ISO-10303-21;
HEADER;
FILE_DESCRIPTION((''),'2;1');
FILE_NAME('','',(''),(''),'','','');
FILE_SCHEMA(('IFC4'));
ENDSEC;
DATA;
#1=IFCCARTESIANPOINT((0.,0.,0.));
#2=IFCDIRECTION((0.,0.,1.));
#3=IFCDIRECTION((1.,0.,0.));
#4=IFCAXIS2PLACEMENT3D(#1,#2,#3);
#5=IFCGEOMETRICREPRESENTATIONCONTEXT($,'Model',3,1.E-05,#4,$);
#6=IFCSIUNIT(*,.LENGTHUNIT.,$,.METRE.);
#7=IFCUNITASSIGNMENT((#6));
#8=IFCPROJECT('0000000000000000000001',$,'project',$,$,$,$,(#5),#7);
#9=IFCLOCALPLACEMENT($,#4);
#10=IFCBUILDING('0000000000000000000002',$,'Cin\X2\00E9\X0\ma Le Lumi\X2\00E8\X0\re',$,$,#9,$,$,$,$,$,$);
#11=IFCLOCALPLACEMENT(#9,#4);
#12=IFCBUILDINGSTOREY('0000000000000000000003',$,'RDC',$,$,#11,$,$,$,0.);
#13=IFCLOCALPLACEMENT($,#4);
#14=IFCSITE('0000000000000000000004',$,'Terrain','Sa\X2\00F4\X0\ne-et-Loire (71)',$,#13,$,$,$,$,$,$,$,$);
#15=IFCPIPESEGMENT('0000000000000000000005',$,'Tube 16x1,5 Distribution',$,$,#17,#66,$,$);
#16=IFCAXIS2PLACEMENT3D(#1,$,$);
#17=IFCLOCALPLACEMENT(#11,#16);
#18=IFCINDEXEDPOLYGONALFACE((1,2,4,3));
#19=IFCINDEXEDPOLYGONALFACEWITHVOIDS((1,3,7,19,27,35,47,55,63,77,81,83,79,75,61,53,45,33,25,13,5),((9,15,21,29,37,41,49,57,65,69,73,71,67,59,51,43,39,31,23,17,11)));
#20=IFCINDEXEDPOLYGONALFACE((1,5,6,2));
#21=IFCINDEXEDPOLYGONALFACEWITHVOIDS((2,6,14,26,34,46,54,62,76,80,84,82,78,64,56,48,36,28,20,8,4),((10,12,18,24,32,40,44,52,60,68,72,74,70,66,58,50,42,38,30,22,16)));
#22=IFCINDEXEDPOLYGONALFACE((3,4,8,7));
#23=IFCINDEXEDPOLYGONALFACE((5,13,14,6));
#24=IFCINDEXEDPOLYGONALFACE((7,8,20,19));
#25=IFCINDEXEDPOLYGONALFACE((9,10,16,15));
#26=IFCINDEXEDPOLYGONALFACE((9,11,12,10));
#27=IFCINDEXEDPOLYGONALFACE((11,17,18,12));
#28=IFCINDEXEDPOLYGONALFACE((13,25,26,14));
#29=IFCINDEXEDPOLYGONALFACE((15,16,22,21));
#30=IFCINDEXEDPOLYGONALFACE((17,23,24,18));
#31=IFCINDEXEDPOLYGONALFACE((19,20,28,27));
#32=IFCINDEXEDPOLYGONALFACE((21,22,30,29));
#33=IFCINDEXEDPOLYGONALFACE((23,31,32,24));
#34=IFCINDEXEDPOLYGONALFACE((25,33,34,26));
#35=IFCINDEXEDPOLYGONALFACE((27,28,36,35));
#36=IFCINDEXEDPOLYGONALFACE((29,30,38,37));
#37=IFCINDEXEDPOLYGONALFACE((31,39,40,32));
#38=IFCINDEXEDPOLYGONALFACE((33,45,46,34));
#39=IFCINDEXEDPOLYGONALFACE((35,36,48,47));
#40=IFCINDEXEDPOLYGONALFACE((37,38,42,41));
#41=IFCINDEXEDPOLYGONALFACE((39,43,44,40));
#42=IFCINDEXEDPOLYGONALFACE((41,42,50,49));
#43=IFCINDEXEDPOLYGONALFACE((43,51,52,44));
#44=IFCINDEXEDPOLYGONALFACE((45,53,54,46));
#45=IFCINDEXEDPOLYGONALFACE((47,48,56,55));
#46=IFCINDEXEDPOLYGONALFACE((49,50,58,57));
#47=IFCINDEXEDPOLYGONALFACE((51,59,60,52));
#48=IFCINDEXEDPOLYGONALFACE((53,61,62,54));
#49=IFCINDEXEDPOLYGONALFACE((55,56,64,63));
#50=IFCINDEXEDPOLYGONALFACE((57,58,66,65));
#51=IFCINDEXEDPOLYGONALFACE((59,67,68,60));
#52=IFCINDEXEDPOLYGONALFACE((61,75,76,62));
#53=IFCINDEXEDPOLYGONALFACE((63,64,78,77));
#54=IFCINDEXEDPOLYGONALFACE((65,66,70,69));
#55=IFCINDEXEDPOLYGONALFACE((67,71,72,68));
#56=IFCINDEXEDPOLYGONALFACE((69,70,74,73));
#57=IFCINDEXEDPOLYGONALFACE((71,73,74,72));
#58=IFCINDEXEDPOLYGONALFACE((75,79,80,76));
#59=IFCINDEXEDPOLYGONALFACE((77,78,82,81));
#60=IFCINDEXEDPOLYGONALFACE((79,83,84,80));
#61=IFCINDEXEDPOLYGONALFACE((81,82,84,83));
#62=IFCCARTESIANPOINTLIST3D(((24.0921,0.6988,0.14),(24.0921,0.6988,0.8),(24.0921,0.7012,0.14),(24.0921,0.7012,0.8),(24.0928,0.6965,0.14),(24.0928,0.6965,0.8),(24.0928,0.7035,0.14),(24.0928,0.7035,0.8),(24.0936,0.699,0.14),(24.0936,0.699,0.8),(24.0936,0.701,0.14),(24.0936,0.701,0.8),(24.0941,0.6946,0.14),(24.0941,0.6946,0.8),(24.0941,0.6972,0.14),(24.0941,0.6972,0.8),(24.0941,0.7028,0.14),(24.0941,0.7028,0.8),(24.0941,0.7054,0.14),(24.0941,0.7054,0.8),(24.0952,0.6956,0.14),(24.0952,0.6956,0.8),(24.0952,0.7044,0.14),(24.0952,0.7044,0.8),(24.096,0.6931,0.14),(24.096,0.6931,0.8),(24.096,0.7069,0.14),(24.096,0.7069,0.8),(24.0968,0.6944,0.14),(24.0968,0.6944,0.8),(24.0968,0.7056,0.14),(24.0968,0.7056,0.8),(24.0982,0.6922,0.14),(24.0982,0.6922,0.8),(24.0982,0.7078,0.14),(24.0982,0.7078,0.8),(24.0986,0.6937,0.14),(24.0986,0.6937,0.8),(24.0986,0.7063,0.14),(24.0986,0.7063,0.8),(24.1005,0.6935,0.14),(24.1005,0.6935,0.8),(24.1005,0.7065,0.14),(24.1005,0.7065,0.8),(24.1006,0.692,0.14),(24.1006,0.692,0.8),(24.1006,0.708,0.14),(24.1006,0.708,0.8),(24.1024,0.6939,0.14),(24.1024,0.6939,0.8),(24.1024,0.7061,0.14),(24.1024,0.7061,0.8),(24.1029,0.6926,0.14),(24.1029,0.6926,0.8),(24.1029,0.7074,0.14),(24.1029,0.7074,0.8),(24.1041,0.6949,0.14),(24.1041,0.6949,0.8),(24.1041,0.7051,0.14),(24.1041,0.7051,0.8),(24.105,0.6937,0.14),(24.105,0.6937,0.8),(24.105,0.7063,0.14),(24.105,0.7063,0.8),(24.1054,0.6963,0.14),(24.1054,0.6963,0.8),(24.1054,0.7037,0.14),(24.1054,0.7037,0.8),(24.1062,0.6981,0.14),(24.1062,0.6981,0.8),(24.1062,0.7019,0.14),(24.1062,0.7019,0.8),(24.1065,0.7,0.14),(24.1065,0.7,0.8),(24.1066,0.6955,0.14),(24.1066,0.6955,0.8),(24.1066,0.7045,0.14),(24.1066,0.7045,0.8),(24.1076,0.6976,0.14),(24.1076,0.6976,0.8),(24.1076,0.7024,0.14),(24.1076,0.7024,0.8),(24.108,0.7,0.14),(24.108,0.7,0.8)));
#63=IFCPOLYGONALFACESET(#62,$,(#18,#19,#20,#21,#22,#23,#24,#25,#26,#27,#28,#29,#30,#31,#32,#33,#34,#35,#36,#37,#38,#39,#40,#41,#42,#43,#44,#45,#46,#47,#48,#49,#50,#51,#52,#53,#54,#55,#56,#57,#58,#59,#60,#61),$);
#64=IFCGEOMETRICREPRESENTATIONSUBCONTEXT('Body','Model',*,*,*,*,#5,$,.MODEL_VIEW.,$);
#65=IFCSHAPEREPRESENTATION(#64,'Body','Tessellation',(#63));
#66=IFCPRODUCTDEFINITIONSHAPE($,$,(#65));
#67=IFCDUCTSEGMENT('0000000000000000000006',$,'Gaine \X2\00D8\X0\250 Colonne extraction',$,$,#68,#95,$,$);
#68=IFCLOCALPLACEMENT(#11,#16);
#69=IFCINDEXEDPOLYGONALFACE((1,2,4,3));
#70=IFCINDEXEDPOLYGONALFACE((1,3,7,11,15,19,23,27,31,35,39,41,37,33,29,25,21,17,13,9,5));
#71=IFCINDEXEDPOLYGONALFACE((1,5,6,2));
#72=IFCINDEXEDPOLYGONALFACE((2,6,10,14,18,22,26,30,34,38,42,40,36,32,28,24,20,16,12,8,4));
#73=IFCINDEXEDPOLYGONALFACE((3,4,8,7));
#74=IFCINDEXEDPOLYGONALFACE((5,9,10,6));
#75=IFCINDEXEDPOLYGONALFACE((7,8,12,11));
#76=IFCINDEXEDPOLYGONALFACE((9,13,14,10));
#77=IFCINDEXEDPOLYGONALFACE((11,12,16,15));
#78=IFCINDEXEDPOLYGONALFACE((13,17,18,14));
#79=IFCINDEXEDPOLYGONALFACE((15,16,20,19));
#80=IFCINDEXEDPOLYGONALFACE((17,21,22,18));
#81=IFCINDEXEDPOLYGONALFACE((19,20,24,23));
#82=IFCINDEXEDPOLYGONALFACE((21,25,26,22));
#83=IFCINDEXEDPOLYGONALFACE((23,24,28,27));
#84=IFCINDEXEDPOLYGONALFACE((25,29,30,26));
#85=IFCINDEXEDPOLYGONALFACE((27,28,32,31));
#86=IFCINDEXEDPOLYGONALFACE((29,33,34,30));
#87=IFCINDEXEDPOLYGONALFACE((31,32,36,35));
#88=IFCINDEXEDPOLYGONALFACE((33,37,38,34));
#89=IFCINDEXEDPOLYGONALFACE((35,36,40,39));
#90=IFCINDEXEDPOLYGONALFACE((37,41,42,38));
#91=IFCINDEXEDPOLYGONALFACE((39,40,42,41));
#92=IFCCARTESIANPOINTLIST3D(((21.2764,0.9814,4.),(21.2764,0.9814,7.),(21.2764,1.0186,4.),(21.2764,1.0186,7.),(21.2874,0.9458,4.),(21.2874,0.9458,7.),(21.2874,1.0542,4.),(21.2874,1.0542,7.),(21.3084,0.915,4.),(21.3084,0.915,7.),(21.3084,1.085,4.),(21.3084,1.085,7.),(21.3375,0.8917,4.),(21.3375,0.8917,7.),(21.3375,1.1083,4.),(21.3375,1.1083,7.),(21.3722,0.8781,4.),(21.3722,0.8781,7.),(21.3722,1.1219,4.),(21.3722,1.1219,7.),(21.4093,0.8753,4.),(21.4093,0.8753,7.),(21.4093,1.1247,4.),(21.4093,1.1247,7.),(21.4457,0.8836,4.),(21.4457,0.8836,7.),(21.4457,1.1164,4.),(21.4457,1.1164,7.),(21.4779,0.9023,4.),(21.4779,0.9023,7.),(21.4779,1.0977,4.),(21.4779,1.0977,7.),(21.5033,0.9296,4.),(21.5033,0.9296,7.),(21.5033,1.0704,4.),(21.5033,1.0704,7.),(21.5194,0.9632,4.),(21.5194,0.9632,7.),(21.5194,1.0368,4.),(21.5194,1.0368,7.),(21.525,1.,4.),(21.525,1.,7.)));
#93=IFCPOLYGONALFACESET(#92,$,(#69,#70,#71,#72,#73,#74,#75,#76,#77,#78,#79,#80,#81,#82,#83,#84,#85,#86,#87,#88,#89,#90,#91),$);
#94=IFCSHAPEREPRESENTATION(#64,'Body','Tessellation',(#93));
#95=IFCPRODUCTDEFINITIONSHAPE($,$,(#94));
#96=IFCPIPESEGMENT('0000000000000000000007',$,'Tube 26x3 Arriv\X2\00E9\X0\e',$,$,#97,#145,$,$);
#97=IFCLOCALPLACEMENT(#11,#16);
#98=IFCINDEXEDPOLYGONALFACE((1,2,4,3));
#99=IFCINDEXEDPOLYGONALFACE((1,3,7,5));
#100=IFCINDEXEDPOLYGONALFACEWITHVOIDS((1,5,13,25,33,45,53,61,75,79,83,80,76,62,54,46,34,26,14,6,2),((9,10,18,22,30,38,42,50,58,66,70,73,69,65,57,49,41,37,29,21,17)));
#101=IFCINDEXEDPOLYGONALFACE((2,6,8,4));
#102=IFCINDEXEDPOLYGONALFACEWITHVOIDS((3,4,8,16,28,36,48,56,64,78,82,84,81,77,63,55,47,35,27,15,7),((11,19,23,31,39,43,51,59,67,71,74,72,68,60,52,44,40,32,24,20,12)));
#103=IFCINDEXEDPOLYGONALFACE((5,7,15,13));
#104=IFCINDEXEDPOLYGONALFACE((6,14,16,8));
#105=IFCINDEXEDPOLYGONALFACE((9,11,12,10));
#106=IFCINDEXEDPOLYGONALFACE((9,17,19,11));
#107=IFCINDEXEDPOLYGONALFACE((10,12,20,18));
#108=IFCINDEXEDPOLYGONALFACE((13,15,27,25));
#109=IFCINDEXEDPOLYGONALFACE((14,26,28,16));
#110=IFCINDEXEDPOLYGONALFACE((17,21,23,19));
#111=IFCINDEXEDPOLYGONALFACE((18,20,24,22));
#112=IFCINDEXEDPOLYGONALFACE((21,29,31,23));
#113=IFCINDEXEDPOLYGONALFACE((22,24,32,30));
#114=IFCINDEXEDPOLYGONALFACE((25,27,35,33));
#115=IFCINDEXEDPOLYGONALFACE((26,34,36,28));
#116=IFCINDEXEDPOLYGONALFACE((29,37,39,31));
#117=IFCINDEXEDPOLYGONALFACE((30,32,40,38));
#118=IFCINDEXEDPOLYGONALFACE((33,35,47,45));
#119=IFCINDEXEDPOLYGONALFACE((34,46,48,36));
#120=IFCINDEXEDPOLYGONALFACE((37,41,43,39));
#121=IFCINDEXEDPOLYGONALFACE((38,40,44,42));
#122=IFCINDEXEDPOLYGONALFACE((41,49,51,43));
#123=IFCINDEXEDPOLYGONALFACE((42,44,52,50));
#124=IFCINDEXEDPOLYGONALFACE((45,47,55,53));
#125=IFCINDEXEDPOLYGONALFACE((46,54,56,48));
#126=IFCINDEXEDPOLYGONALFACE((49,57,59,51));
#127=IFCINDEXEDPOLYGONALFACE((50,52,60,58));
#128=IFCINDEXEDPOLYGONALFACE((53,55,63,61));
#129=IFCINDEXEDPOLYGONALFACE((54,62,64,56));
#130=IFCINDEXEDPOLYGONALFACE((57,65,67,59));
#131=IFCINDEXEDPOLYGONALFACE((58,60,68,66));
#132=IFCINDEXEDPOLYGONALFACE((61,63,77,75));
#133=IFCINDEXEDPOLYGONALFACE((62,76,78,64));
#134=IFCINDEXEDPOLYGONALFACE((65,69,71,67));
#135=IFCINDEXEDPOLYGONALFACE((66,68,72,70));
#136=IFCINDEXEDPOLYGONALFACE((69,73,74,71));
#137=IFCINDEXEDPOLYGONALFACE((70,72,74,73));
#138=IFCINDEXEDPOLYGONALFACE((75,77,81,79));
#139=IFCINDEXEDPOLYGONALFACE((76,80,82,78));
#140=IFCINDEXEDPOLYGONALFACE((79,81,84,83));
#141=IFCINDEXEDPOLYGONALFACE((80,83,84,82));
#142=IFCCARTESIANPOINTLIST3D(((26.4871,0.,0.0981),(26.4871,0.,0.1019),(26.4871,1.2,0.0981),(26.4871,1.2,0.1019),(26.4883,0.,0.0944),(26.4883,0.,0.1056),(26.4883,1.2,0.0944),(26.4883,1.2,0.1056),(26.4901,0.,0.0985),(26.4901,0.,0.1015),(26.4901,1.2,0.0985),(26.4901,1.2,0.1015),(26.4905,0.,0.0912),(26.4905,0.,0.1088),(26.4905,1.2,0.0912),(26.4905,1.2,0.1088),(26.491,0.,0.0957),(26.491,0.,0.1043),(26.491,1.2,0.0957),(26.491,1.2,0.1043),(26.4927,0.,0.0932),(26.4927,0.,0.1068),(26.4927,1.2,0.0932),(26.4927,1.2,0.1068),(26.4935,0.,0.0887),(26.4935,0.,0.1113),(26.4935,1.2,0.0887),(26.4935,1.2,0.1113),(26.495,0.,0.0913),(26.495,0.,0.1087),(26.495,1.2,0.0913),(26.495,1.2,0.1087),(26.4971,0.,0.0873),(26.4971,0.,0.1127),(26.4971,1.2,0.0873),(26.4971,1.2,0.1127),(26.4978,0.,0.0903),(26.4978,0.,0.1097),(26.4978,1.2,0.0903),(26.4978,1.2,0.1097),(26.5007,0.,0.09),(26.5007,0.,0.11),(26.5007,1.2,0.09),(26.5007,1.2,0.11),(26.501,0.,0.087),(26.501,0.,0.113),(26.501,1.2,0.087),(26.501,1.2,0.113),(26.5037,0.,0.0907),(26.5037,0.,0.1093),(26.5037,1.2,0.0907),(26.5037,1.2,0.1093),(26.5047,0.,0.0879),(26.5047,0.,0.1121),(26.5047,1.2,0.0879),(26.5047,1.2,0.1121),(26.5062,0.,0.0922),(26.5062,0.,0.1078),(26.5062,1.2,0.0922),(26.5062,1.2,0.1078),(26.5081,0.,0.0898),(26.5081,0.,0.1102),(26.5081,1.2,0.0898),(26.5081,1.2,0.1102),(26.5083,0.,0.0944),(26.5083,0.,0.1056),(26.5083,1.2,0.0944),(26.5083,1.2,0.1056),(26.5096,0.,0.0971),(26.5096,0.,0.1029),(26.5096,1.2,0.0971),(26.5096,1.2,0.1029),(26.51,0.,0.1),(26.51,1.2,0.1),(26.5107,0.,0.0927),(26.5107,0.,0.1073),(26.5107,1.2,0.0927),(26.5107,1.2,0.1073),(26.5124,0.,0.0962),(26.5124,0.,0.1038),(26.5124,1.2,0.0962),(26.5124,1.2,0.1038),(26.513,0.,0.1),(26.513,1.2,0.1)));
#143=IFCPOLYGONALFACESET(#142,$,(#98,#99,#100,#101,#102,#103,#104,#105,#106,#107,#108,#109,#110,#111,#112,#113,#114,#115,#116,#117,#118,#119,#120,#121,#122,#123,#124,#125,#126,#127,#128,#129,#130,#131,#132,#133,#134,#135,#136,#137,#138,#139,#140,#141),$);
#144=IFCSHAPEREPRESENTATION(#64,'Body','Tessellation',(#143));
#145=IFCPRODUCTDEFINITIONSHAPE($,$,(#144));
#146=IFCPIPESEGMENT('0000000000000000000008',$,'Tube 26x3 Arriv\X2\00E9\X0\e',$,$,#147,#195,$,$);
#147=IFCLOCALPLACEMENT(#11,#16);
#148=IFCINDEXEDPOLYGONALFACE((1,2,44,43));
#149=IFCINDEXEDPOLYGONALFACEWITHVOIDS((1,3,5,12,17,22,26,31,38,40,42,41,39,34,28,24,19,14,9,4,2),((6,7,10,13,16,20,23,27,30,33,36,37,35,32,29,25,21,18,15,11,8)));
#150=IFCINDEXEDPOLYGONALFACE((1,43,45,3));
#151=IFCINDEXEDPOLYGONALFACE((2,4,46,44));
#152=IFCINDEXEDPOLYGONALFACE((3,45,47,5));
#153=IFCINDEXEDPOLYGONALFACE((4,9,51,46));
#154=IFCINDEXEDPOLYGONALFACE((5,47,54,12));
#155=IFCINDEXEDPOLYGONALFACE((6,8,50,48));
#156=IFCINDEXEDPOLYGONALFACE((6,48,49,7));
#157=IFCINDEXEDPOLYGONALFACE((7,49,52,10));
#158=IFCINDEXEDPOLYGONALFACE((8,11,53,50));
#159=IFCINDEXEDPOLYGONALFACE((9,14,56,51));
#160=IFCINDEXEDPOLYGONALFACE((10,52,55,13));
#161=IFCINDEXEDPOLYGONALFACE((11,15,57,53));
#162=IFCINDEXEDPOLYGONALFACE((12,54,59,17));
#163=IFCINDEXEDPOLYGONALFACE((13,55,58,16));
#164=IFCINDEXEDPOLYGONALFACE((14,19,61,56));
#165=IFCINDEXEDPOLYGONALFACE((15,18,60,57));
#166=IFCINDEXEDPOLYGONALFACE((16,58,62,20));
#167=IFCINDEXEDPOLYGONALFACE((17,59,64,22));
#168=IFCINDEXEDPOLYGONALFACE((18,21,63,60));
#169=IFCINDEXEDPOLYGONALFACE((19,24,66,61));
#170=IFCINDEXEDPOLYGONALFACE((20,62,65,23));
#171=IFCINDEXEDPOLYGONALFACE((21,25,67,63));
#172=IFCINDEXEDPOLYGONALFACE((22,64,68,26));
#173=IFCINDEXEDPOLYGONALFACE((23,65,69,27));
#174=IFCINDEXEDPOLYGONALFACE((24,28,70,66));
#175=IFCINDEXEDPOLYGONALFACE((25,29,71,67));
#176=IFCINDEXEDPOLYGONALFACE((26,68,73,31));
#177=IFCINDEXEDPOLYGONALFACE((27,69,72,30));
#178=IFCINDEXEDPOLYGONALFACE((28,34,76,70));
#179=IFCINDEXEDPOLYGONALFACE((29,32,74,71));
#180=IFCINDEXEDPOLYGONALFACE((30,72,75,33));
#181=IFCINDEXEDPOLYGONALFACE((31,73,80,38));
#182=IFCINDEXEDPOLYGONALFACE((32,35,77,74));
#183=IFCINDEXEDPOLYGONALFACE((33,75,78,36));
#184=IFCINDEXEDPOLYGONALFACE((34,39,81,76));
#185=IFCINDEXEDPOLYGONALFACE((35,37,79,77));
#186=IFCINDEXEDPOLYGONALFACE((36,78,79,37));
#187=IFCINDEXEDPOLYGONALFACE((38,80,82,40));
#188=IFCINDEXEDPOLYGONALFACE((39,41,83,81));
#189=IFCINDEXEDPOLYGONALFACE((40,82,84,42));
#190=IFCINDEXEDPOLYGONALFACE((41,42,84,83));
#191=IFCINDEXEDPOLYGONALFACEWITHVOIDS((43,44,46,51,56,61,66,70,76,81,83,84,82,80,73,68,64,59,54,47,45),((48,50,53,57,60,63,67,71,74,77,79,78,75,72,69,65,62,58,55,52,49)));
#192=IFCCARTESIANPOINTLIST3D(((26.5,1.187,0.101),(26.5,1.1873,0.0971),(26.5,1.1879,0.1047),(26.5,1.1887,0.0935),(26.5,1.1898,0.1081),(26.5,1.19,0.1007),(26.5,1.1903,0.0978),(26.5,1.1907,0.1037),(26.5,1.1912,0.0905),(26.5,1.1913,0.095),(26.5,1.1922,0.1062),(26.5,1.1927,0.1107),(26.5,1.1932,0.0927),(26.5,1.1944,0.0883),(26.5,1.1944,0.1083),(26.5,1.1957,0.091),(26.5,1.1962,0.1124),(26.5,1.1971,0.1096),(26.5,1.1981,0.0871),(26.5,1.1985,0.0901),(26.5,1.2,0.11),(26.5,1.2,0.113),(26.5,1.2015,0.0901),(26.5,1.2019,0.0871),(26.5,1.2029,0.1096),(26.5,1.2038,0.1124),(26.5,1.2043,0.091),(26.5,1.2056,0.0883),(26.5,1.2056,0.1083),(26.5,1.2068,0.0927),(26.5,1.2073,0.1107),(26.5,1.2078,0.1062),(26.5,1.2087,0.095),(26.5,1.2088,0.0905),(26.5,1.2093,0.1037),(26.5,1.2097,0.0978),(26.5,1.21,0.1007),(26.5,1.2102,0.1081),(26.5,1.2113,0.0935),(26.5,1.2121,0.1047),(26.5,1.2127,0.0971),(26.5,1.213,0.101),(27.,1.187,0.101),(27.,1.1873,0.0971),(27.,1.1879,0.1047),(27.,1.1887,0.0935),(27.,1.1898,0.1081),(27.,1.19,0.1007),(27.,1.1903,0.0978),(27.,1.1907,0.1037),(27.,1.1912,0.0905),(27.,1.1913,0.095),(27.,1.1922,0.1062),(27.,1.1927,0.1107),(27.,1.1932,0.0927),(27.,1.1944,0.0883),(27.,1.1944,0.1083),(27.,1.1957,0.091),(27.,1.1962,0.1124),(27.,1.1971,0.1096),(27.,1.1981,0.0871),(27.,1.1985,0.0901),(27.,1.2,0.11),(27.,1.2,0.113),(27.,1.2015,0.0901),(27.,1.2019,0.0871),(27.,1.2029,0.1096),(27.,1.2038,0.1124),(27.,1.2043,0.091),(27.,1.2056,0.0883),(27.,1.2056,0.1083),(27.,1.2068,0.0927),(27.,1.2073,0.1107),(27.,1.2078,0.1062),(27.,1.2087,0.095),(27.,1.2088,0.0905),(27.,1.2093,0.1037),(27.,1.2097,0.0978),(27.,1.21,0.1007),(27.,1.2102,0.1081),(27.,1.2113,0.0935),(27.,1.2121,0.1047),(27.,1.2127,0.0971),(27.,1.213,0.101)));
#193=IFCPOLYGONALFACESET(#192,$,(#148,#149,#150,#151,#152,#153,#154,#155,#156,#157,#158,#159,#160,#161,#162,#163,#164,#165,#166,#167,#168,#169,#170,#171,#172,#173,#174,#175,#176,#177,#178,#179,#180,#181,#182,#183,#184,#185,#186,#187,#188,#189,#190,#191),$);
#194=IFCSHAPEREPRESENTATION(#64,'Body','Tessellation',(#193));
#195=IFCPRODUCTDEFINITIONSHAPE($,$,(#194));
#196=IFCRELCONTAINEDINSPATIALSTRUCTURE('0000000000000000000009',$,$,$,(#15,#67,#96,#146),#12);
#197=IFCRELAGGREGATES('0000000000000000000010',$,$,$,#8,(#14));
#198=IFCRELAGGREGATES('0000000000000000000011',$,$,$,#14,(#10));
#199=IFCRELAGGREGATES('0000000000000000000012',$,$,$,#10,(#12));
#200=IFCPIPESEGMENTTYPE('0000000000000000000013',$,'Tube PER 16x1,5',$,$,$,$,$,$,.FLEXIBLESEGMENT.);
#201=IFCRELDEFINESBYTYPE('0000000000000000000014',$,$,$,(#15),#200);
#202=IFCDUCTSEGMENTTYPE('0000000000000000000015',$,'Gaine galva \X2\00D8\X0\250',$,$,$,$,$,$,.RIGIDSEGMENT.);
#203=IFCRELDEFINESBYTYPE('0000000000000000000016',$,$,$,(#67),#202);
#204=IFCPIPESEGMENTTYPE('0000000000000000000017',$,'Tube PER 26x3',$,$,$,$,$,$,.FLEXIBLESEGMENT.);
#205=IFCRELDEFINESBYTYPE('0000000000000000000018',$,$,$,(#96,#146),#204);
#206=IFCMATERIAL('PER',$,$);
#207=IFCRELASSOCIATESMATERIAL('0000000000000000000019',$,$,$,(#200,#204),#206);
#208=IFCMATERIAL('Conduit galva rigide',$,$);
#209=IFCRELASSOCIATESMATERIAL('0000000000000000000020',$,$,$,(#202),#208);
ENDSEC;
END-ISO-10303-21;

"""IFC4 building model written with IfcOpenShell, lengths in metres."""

from ifc_helpers import new_model, si_unit, frame, origin_with_axes, place, context, subcontext, project, spatial, circle, hollow_circle, extrude, material, type_object, element, save


model = new_model("IFC4")

# Units and contexts
model_context = context("Model", 3, precision=1e-05, world=origin_with_axes())
body_context = subcontext(model_context, "Body", "Model", "MODEL_VIEW")
ifc_project = project(units=[si_unit("LENGTHUNIT", "METRE")], contexts=[model_context])

# Site, building, storey
site_placement = place(None, origin_with_axes())
site = spatial("IfcSite", under=ifc_project, at=site_placement, Name="Terrain", Description="Saône-et-Loire (71)")
building_placement = place(None, origin_with_axes())
building = spatial("IfcBuilding", under=site, at=building_placement, Name="Cinéma Le Lumière")
storey_placement = place(building_placement, origin_with_axes())
storey = spatial("IfcBuildingStorey", under=building, at=storey_placement, Name="RDC", Elevation=0.0)

# Shared definitions
ifc_material_1 = material(Name="Conduit galva rigide")

# Pipe segment
ifc_material_2 = material(Name="PER")
pipe_segment_type_1 = type_object("IfcPipeSegmentType", Name="Tube PER 16x1,5", PredefinedType="FLEXIBLESEGMENT", material=ifc_material_2)
pipe_segment_1_placement = place(storey_placement, frame((24.1, 0.7, 0.14), z_axis=(0.0, 0.0, 1.0), x_axis=(1.0, 0.0, 0.0)))
element("IfcPipeSegment", 1, at=pipe_segment_1_placement, inside=storey, type_object=pipe_segment_type_1, Name="Tube 16x1,5 Distribution", context=body_context, shape_type="SweptSolid", body=[
    extrude(hollow_circle(Radius=0.008, WallThickness=0.0015), origin_with_axes(), (0.0, 0.0, 1.0), 0.66),
])

# Duct segment
duct_segment_type_1 = type_object("IfcDuctSegmentType", Name="Gaine galva Ø250", PredefinedType="RIGIDSEGMENT", material=ifc_material_1)
duct_segment_1_placement = place(storey_placement, frame((21.4, 1.0, 4.0), z_axis=(0.0, 0.0, 1.0), x_axis=(1.0, 0.0, 0.0)))
element("IfcDuctSegment", 2, at=duct_segment_1_placement, inside=storey, type_object=duct_segment_type_1, Name="Gaine Ø250 Colonne extraction", context=body_context, shape_type="SweptSolid", body=[
    extrude(circle(Radius=0.125), origin_with_axes(), (0.0, 0.0, 1.0), 3.0),
])

# Pipe segments
pipe_segment_type_2 = type_object("IfcPipeSegmentType", Name="Tube PER 26x3", PredefinedType="FLEXIBLESEGMENT", material=ifc_material_2)
pipe_segment_2_placement = place(storey_placement, frame((26.5, 0.0, 0.1), z_axis=(0.0, 1.0, 0.0), x_axis=(1.0, 0.0, 0.0)))
element("IfcPipeSegment", 3, at=pipe_segment_2_placement, inside=storey, type_object=pipe_segment_type_2, Name="Tube 26x3 Arrivée", context=body_context, shape_type="SweptSolid", body=[
    extrude(hollow_circle(Radius=0.013, WallThickness=0.003), origin_with_axes(), (0.0, 0.0, 1.0), 1.2),
])
pipe_segment_3_placement = place(storey_placement, frame((26.5, 1.2, 0.1), z_axis=(1.0, 0.0, 0.0), x_axis=(0.0, 0.0, 1.0)))
element("IfcPipeSegment", 4, at=pipe_segment_3_placement, inside=storey, type_object=pipe_segment_type_2, Name="Tube 26x3 Arrivée", context=body_context, shape_type="SweptSolid", body=[
    extrude(hollow_circle(Radius=0.013, WallThickness=0.003), origin_with_axes(), (0.0, 0.0, 1.0), 0.5),
])

save(model, "model.ifc")
